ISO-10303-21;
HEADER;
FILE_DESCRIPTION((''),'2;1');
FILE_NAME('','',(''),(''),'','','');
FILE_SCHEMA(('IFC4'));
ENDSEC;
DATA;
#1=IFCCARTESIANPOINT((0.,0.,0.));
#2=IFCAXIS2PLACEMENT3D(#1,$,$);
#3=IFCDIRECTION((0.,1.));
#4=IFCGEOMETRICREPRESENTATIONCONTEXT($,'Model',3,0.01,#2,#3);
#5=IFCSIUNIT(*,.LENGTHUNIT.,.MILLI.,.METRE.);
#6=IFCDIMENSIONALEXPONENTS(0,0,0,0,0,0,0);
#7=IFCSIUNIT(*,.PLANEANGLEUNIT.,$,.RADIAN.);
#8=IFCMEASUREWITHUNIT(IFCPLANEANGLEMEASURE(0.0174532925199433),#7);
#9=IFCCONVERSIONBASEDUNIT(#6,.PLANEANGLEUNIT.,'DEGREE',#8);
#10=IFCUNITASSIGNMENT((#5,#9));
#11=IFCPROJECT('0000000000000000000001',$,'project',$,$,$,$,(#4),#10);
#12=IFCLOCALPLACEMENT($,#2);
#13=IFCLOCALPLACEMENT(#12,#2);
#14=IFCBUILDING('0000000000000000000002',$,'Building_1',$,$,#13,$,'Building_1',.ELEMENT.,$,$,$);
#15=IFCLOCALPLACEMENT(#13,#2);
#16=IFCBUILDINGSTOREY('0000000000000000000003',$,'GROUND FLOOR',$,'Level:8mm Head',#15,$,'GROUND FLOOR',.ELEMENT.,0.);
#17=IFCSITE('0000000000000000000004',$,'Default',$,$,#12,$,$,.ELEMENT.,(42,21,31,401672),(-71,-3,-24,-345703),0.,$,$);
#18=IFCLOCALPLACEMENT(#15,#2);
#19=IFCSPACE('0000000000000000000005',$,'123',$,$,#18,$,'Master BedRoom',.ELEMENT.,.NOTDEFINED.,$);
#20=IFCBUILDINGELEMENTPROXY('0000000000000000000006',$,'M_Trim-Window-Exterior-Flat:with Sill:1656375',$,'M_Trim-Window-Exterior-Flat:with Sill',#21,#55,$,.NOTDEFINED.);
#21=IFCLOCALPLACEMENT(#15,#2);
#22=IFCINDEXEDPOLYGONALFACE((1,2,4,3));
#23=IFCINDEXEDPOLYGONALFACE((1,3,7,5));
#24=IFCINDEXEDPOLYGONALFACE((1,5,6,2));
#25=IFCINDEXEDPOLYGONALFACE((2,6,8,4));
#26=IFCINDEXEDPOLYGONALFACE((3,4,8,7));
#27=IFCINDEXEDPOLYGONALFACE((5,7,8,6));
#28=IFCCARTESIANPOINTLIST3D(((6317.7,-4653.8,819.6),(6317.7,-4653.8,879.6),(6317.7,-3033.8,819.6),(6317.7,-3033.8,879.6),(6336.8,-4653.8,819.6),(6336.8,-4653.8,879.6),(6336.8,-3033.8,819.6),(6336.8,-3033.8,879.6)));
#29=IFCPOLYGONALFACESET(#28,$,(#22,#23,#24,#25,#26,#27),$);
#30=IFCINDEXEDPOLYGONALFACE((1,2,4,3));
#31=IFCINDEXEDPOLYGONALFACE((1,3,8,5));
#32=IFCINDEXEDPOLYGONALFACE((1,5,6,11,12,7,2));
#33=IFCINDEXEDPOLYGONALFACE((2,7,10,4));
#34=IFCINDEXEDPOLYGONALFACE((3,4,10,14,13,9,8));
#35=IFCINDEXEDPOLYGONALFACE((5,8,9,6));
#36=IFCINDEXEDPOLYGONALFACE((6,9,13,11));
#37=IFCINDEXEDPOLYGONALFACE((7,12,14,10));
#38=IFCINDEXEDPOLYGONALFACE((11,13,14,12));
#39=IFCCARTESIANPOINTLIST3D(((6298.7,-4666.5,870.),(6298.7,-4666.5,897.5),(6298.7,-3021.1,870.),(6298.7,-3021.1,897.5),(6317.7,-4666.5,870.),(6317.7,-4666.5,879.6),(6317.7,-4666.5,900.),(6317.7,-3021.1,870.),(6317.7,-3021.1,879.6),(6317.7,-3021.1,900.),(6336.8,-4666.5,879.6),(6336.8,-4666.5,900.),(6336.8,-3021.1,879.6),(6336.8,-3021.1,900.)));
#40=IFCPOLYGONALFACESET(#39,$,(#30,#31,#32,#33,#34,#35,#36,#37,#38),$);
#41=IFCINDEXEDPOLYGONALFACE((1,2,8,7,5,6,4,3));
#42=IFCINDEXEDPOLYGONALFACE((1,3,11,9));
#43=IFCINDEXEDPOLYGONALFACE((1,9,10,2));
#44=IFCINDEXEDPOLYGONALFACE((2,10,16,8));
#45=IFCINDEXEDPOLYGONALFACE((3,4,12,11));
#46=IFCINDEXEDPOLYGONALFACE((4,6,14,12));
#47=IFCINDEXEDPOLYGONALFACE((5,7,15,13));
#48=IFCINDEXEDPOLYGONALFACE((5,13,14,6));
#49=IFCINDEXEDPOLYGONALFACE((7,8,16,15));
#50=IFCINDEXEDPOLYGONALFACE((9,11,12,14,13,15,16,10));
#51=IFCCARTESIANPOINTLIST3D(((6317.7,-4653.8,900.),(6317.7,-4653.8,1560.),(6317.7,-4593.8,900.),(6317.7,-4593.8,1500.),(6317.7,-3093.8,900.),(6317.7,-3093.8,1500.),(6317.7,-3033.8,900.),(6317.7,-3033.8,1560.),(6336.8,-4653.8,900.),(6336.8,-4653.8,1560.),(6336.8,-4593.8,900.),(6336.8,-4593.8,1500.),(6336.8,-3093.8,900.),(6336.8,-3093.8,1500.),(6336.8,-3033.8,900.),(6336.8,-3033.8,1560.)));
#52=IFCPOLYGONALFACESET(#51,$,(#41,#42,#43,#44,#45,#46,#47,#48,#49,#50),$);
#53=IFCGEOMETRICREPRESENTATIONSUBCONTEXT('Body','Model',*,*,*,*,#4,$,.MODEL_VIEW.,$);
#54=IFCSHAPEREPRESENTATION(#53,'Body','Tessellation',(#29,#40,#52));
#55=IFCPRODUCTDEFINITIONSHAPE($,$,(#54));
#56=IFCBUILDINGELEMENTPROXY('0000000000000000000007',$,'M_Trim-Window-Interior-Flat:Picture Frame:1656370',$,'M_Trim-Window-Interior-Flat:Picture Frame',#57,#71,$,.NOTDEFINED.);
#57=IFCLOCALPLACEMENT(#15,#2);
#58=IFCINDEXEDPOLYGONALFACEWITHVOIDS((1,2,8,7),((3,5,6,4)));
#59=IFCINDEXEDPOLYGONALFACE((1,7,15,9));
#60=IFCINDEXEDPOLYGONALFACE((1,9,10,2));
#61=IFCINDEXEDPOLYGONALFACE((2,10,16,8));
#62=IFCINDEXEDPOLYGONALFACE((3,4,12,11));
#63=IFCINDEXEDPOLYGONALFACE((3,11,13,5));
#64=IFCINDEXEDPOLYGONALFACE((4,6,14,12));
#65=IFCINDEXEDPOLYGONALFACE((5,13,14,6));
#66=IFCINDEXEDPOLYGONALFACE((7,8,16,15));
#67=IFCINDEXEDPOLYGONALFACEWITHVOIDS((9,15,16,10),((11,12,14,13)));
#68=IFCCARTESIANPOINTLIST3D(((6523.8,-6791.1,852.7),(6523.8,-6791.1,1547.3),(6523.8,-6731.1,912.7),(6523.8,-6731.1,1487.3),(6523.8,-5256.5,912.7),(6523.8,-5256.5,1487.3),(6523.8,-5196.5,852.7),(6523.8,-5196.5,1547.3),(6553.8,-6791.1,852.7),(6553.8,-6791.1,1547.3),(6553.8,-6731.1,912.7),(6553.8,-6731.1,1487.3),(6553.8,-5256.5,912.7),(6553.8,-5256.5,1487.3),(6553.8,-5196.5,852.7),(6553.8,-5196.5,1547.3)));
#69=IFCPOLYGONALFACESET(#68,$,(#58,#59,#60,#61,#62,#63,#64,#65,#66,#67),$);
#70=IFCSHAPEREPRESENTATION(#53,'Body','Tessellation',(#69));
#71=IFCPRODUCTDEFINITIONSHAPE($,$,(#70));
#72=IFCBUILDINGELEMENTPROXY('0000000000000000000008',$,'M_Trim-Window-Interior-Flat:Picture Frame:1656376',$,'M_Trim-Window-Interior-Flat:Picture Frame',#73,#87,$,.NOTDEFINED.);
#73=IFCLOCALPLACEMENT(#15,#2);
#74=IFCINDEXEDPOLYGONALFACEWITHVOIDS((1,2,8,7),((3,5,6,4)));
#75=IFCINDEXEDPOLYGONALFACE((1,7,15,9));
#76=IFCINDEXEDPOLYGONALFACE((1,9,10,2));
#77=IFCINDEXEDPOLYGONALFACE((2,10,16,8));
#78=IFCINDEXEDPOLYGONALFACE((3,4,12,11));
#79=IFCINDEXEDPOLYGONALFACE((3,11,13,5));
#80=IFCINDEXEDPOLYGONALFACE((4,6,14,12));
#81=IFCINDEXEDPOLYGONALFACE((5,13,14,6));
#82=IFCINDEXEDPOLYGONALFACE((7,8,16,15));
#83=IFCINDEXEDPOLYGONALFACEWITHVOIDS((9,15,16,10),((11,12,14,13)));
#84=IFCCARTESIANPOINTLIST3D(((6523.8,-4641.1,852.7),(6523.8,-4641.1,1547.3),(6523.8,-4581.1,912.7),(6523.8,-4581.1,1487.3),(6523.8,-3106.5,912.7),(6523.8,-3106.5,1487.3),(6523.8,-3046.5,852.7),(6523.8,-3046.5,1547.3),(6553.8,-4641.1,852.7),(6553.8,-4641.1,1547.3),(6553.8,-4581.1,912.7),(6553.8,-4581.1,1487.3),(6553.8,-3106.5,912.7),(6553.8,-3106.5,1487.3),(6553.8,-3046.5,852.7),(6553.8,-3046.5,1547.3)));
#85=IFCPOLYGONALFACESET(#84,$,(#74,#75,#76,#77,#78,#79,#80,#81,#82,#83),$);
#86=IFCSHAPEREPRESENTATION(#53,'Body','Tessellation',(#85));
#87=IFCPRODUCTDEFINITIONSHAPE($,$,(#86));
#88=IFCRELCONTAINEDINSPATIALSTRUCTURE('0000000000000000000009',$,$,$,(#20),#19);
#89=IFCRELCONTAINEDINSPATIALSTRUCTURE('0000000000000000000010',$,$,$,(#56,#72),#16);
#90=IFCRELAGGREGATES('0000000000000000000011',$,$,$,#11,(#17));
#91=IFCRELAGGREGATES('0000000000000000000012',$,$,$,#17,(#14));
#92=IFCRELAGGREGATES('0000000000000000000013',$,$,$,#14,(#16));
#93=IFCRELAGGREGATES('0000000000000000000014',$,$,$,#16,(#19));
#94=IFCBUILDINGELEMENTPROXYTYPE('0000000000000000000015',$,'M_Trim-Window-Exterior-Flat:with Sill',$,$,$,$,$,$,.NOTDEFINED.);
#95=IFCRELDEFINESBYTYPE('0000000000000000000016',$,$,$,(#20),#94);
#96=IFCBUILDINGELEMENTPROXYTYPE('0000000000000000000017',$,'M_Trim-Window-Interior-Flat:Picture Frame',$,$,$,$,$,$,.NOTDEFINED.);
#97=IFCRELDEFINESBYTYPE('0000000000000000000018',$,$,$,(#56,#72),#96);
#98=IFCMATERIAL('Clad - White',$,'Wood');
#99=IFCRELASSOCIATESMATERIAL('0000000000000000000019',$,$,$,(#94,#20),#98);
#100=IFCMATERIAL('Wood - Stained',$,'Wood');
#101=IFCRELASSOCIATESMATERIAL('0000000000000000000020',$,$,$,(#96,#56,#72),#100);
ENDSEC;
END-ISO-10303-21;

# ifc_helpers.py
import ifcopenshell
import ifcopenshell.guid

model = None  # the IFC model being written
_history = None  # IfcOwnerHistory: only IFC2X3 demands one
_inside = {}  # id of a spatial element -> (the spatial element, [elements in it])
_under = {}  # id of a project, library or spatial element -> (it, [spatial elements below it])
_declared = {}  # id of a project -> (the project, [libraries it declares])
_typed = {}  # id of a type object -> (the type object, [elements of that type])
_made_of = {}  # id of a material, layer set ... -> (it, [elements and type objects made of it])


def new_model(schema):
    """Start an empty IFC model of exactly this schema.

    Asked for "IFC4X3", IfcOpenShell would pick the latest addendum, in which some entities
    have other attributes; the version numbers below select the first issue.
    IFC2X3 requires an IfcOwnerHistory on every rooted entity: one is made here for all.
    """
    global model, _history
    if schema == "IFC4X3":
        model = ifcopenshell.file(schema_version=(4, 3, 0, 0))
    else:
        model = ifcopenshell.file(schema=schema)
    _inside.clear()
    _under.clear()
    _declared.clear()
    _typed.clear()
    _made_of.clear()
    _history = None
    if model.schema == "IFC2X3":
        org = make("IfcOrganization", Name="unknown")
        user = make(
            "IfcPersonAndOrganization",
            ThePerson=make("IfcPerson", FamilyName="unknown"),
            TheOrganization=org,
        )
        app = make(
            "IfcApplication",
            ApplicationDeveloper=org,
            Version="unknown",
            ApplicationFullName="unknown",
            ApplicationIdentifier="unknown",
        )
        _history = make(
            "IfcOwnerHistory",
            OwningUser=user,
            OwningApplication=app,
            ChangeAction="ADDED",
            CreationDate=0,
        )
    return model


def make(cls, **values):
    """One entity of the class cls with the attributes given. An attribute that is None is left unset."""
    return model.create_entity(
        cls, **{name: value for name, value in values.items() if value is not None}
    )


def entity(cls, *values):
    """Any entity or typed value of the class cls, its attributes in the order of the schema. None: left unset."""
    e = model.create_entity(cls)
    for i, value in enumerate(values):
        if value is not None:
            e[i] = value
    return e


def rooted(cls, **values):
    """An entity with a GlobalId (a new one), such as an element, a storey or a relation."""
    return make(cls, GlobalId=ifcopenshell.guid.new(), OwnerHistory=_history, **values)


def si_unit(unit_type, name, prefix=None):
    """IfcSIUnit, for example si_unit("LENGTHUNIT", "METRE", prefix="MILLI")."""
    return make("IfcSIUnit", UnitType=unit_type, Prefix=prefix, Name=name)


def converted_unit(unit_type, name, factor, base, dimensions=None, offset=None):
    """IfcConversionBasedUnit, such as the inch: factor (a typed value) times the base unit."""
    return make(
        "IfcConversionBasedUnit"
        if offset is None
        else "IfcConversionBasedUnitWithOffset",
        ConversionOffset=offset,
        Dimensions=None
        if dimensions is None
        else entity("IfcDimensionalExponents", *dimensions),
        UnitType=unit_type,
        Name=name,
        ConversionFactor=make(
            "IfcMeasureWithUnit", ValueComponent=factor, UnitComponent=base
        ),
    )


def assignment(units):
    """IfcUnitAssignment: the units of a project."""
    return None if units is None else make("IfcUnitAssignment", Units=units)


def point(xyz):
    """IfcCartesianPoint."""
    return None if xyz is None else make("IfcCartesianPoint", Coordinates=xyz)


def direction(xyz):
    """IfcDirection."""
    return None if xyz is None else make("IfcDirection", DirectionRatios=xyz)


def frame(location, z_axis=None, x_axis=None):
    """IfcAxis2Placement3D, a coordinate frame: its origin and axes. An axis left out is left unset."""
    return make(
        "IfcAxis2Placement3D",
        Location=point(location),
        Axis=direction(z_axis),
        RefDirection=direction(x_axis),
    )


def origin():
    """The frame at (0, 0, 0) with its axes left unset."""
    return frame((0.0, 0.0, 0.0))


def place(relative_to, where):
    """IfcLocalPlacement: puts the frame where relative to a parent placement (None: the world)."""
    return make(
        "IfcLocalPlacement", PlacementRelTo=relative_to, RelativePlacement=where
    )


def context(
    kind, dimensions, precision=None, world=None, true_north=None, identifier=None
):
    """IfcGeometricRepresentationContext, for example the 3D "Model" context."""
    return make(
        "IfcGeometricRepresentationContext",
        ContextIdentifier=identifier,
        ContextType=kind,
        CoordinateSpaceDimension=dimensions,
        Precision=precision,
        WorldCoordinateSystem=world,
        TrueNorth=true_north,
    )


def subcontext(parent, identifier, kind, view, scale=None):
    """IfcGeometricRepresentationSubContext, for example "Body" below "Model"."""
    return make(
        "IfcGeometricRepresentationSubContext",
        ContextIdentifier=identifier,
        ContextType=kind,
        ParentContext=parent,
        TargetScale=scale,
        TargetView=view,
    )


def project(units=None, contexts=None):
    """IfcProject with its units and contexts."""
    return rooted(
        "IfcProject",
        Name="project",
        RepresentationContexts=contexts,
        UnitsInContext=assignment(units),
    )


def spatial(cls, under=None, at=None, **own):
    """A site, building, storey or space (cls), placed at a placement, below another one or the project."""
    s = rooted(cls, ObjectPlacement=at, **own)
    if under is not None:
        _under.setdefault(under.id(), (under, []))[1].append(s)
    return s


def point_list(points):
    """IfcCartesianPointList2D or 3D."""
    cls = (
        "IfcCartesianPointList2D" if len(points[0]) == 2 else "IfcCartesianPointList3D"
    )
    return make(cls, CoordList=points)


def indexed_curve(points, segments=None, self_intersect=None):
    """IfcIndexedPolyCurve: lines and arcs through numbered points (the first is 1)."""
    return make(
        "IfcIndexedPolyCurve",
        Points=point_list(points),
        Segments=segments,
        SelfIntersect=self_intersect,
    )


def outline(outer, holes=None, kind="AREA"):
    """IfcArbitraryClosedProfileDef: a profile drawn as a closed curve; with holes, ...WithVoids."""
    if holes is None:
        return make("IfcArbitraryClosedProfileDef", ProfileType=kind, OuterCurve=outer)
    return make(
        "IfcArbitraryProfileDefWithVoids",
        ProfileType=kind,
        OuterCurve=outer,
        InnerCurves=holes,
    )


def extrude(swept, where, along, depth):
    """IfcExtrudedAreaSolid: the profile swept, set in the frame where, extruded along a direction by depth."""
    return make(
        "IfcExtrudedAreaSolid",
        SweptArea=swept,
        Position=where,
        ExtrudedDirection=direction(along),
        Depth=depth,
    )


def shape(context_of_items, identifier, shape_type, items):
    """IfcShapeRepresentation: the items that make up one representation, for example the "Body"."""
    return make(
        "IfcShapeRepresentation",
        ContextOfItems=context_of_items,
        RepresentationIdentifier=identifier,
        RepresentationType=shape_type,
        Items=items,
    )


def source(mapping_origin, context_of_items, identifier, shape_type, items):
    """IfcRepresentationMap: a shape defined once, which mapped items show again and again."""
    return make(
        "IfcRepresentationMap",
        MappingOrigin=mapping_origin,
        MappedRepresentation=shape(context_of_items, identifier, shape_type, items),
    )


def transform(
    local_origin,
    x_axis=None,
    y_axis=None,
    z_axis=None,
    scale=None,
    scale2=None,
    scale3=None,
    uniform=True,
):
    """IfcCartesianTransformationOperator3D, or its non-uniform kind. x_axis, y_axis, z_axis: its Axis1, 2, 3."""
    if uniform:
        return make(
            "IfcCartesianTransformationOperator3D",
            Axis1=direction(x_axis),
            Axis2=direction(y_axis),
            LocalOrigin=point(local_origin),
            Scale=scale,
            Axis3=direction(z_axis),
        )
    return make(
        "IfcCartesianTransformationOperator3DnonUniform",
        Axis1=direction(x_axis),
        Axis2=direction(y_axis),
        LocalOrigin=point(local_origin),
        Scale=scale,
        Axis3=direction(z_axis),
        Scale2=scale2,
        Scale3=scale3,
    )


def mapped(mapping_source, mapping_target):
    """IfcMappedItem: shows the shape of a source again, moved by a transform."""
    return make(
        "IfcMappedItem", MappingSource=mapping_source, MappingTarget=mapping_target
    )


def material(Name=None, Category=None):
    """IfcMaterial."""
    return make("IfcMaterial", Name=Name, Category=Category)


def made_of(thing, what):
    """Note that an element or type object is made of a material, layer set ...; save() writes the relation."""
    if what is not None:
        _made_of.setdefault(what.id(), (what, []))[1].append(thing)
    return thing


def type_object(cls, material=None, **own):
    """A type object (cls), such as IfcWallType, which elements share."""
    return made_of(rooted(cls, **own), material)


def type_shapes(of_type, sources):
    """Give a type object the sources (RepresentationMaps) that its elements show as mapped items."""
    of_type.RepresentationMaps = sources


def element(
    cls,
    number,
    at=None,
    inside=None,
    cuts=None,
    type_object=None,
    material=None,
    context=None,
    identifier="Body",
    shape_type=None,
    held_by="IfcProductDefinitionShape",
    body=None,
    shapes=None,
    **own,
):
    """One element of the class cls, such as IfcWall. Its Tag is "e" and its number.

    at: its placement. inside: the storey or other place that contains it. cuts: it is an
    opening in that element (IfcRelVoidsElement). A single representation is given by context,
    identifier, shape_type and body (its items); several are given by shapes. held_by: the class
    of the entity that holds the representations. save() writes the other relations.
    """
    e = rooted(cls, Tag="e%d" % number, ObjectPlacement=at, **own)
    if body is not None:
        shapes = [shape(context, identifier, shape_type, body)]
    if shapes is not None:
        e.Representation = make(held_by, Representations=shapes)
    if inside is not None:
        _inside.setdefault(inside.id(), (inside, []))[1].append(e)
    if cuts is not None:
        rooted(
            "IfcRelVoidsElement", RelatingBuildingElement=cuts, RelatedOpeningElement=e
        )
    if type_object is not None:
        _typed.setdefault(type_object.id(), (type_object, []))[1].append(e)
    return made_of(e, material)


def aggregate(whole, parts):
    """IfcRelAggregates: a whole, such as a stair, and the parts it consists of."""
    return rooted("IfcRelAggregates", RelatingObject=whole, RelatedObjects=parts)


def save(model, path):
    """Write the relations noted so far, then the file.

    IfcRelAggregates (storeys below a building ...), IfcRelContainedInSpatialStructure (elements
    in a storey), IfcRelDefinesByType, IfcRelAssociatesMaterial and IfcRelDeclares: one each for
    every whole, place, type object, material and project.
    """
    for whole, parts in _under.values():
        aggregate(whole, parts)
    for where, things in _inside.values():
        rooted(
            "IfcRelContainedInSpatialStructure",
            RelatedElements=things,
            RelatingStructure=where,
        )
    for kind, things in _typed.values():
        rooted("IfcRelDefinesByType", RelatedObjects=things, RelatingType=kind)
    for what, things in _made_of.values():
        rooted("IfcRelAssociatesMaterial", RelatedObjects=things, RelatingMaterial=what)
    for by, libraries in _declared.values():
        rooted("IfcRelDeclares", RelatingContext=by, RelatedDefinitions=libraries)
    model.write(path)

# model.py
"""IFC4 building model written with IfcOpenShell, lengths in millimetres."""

from ifc_helpers import new_model, entity, si_unit, converted_unit, direction, frame, origin, place, context, subcontext, project, spatial, indexed_curve, outline, extrude, source, transform, mapped, material, type_object, type_shapes, element, save


model = new_model("IFC4")

# Units and contexts
model_context = context("Model", 3, precision=0.01, world=origin(), true_north=direction((0.0, 1.0)))
body_context = subcontext(model_context, "Body", "Model", "MODEL_VIEW")
ifc_project = project(units=[si_unit("LENGTHUNIT", "METRE", prefix="MILLI"), converted_unit("PLANEANGLEUNIT", "DEGREE", entity("IfcPlaneAngleMeasure", 0.0174532925199433), si_unit("PLANEANGLEUNIT", "RADIAN"), dimensions=[0, 0, 0, 0, 0, 0, 0])], contexts=[model_context])

# Site, building, storey
site_placement = place(None, origin())
site = spatial("IfcSite", under=ifc_project, at=site_placement, Name="Default", CompositionType="ELEMENT", RefLatitude=(42, 21, 31, 401672), RefLongitude=(-71, -3, -24, -345703), RefElevation=0.0)
building_placement = place(site_placement, origin())
building = spatial("IfcBuilding", under=site, at=building_placement, Name="Building_1", LongName="Building_1", CompositionType="ELEMENT")
storey_placement = place(building_placement, origin())
storey = spatial("IfcBuildingStorey", under=building, at=storey_placement, Name="GROUND FLOOR", ObjectType="Level:8mm Head", LongName="GROUND FLOOR", CompositionType="ELEMENT", Elevation=0.0)

# Shared definitions
ifc_material_1 = material(Name="Wood - Stained", Category="Wood")

# Shared definitions
space_1_placement = place(storey_placement, origin())
space_1 = spatial("IfcSpace", under=storey, at=space_1_placement, Name="123", LongName="Master BedRoom", CompositionType="ELEMENT", PredefinedType="NOTDEFINED")

# Building element proxies
ifc_material_2 = material(Name="Clad - White", Category="Wood")
building_element_proxy_type_1 = type_object("IfcBuildingElementProxyType", Name="M_Trim-Window-Exterior-Flat:with Sill", PredefinedType="NOTDEFINED", material=ifc_material_2)
shared_shape_1 = source(origin(), body_context, "Body", "SweptSolid", [
    extrude(outline(indexed_curve([(-30.0, -810.0), (30.0, -810.0), (30.0, 810.0), (-30.0, 810.0), (-30.0, -810.0)], self_intersect=False)), frame((0.0, 650.4, 0.0), z_axis=(0.0, 0.0, 1.0), x_axis=(0.0, 1.0, 0.0)), (0.0, 0.0, 1.0), 19.1),
    extrude(outline(indexed_curve([(-15.2, -19.0), (12.3, -19.0), (14.8, 0.0), (14.8, 19.0), (-5.7, 19.0), (-5.7, 0.0), (-15.2, 0.0), (-15.2, -19.0)], self_intersect=False)), frame((-822.7, 614.8, 19.0), z_axis=(1.0, 0.0, 0.0), x_axis=(0.0, -1.0, 0.0)), (0.0, 0.0, 1.0), 1645.4),
    extrude(outline(indexed_curve([(-810.0, -345.0), (810.0, -345.0), (810.0, 315.0), (750.0, 315.0), (750.0, -285.0), (-750.0, -285.0), (-750.0, 315.0), (-810.0, 315.0), (-810.0, -345.0)], self_intersect=False)), frame((0.0, 285.0, 0.0)), (0.0, 0.0, 1.0), 19.1),
])
type_shapes(building_element_proxy_type_1, [shared_shape_1])
for number, where, z_axis, x_axis, name in (
    (1, (6336.8, -3843.8, 1500.0), (-1.0, 0.0, 0.0), (0.0, 1.0, 0.0), "M_Trim-Window-Exterior-Flat:with Sill:1656375"),
):
    element("IfcBuildingElementProxy", number, at=place(space_1_placement, frame(where, z_axis=z_axis, x_axis=x_axis)), inside=space_1, type_object=building_element_proxy_type_1, material=ifc_material_2, Name=name, ObjectType="M_Trim-Window-Exterior-Flat:with Sill", PredefinedType="NOTDEFINED", context=body_context, shape_type="MappedRepresentation", body=[
        mapped(shared_shape_1, transform((0.0, 0.0, 0.0), scale=1.0)),
    ])
building_element_proxy_type_2 = type_object("IfcBuildingElementProxyType", Name="M_Trim-Window-Interior-Flat:Picture Frame", PredefinedType="NOTDEFINED", material=ifc_material_1)
shared_shape_2 = source(origin(), body_context, "Body", "SweptSolid", [
    extrude(outline(indexed_curve([(-347.3, -797.3), (347.3, -797.3), (347.3, 797.3), (-347.3, 797.3), (-347.3, -797.3)], self_intersect=False), holes=[indexed_curve([(-287.3, -737.3), (-287.3, 737.3), (287.3, 737.3), (287.3, -737.3), (-287.3, -737.3)], self_intersect=False)]), frame((0.0, 300.0, 0.0), z_axis=(0.0, 0.0, 1.0), x_axis=(0.0, 1.0, 0.0)), (0.0, 0.0, 1.0), 30.0),
])
type_shapes(building_element_proxy_type_2, [shared_shape_2])
for number, where, z_axis, x_axis, name in (
    (2, (6523.8, -5993.8, 1500.0), (1.0, 0.0, 0.0), (0.0, -1.0, 0.0), "M_Trim-Window-Interior-Flat:Picture Frame:1656370"),
    (3, (6523.8, -3843.8, 1500.0), (1.0, 0.0, 0.0), (0.0, -1.0, 0.0), "M_Trim-Window-Interior-Flat:Picture Frame:1656376"),
):
    element("IfcBuildingElementProxy", number, at=place(storey_placement, frame(where, z_axis=z_axis, x_axis=x_axis)), inside=storey, type_object=building_element_proxy_type_2, material=ifc_material_1, Name=name, ObjectType="M_Trim-Window-Interior-Flat:Picture Frame", PredefinedType="NOTDEFINED", context=body_context, shape_type="MappedRepresentation", body=[
        mapped(shared_shape_2, transform((0.0, 0.0, 0.0), scale=1.0)),
    ])

save(model, "model.ifc")
